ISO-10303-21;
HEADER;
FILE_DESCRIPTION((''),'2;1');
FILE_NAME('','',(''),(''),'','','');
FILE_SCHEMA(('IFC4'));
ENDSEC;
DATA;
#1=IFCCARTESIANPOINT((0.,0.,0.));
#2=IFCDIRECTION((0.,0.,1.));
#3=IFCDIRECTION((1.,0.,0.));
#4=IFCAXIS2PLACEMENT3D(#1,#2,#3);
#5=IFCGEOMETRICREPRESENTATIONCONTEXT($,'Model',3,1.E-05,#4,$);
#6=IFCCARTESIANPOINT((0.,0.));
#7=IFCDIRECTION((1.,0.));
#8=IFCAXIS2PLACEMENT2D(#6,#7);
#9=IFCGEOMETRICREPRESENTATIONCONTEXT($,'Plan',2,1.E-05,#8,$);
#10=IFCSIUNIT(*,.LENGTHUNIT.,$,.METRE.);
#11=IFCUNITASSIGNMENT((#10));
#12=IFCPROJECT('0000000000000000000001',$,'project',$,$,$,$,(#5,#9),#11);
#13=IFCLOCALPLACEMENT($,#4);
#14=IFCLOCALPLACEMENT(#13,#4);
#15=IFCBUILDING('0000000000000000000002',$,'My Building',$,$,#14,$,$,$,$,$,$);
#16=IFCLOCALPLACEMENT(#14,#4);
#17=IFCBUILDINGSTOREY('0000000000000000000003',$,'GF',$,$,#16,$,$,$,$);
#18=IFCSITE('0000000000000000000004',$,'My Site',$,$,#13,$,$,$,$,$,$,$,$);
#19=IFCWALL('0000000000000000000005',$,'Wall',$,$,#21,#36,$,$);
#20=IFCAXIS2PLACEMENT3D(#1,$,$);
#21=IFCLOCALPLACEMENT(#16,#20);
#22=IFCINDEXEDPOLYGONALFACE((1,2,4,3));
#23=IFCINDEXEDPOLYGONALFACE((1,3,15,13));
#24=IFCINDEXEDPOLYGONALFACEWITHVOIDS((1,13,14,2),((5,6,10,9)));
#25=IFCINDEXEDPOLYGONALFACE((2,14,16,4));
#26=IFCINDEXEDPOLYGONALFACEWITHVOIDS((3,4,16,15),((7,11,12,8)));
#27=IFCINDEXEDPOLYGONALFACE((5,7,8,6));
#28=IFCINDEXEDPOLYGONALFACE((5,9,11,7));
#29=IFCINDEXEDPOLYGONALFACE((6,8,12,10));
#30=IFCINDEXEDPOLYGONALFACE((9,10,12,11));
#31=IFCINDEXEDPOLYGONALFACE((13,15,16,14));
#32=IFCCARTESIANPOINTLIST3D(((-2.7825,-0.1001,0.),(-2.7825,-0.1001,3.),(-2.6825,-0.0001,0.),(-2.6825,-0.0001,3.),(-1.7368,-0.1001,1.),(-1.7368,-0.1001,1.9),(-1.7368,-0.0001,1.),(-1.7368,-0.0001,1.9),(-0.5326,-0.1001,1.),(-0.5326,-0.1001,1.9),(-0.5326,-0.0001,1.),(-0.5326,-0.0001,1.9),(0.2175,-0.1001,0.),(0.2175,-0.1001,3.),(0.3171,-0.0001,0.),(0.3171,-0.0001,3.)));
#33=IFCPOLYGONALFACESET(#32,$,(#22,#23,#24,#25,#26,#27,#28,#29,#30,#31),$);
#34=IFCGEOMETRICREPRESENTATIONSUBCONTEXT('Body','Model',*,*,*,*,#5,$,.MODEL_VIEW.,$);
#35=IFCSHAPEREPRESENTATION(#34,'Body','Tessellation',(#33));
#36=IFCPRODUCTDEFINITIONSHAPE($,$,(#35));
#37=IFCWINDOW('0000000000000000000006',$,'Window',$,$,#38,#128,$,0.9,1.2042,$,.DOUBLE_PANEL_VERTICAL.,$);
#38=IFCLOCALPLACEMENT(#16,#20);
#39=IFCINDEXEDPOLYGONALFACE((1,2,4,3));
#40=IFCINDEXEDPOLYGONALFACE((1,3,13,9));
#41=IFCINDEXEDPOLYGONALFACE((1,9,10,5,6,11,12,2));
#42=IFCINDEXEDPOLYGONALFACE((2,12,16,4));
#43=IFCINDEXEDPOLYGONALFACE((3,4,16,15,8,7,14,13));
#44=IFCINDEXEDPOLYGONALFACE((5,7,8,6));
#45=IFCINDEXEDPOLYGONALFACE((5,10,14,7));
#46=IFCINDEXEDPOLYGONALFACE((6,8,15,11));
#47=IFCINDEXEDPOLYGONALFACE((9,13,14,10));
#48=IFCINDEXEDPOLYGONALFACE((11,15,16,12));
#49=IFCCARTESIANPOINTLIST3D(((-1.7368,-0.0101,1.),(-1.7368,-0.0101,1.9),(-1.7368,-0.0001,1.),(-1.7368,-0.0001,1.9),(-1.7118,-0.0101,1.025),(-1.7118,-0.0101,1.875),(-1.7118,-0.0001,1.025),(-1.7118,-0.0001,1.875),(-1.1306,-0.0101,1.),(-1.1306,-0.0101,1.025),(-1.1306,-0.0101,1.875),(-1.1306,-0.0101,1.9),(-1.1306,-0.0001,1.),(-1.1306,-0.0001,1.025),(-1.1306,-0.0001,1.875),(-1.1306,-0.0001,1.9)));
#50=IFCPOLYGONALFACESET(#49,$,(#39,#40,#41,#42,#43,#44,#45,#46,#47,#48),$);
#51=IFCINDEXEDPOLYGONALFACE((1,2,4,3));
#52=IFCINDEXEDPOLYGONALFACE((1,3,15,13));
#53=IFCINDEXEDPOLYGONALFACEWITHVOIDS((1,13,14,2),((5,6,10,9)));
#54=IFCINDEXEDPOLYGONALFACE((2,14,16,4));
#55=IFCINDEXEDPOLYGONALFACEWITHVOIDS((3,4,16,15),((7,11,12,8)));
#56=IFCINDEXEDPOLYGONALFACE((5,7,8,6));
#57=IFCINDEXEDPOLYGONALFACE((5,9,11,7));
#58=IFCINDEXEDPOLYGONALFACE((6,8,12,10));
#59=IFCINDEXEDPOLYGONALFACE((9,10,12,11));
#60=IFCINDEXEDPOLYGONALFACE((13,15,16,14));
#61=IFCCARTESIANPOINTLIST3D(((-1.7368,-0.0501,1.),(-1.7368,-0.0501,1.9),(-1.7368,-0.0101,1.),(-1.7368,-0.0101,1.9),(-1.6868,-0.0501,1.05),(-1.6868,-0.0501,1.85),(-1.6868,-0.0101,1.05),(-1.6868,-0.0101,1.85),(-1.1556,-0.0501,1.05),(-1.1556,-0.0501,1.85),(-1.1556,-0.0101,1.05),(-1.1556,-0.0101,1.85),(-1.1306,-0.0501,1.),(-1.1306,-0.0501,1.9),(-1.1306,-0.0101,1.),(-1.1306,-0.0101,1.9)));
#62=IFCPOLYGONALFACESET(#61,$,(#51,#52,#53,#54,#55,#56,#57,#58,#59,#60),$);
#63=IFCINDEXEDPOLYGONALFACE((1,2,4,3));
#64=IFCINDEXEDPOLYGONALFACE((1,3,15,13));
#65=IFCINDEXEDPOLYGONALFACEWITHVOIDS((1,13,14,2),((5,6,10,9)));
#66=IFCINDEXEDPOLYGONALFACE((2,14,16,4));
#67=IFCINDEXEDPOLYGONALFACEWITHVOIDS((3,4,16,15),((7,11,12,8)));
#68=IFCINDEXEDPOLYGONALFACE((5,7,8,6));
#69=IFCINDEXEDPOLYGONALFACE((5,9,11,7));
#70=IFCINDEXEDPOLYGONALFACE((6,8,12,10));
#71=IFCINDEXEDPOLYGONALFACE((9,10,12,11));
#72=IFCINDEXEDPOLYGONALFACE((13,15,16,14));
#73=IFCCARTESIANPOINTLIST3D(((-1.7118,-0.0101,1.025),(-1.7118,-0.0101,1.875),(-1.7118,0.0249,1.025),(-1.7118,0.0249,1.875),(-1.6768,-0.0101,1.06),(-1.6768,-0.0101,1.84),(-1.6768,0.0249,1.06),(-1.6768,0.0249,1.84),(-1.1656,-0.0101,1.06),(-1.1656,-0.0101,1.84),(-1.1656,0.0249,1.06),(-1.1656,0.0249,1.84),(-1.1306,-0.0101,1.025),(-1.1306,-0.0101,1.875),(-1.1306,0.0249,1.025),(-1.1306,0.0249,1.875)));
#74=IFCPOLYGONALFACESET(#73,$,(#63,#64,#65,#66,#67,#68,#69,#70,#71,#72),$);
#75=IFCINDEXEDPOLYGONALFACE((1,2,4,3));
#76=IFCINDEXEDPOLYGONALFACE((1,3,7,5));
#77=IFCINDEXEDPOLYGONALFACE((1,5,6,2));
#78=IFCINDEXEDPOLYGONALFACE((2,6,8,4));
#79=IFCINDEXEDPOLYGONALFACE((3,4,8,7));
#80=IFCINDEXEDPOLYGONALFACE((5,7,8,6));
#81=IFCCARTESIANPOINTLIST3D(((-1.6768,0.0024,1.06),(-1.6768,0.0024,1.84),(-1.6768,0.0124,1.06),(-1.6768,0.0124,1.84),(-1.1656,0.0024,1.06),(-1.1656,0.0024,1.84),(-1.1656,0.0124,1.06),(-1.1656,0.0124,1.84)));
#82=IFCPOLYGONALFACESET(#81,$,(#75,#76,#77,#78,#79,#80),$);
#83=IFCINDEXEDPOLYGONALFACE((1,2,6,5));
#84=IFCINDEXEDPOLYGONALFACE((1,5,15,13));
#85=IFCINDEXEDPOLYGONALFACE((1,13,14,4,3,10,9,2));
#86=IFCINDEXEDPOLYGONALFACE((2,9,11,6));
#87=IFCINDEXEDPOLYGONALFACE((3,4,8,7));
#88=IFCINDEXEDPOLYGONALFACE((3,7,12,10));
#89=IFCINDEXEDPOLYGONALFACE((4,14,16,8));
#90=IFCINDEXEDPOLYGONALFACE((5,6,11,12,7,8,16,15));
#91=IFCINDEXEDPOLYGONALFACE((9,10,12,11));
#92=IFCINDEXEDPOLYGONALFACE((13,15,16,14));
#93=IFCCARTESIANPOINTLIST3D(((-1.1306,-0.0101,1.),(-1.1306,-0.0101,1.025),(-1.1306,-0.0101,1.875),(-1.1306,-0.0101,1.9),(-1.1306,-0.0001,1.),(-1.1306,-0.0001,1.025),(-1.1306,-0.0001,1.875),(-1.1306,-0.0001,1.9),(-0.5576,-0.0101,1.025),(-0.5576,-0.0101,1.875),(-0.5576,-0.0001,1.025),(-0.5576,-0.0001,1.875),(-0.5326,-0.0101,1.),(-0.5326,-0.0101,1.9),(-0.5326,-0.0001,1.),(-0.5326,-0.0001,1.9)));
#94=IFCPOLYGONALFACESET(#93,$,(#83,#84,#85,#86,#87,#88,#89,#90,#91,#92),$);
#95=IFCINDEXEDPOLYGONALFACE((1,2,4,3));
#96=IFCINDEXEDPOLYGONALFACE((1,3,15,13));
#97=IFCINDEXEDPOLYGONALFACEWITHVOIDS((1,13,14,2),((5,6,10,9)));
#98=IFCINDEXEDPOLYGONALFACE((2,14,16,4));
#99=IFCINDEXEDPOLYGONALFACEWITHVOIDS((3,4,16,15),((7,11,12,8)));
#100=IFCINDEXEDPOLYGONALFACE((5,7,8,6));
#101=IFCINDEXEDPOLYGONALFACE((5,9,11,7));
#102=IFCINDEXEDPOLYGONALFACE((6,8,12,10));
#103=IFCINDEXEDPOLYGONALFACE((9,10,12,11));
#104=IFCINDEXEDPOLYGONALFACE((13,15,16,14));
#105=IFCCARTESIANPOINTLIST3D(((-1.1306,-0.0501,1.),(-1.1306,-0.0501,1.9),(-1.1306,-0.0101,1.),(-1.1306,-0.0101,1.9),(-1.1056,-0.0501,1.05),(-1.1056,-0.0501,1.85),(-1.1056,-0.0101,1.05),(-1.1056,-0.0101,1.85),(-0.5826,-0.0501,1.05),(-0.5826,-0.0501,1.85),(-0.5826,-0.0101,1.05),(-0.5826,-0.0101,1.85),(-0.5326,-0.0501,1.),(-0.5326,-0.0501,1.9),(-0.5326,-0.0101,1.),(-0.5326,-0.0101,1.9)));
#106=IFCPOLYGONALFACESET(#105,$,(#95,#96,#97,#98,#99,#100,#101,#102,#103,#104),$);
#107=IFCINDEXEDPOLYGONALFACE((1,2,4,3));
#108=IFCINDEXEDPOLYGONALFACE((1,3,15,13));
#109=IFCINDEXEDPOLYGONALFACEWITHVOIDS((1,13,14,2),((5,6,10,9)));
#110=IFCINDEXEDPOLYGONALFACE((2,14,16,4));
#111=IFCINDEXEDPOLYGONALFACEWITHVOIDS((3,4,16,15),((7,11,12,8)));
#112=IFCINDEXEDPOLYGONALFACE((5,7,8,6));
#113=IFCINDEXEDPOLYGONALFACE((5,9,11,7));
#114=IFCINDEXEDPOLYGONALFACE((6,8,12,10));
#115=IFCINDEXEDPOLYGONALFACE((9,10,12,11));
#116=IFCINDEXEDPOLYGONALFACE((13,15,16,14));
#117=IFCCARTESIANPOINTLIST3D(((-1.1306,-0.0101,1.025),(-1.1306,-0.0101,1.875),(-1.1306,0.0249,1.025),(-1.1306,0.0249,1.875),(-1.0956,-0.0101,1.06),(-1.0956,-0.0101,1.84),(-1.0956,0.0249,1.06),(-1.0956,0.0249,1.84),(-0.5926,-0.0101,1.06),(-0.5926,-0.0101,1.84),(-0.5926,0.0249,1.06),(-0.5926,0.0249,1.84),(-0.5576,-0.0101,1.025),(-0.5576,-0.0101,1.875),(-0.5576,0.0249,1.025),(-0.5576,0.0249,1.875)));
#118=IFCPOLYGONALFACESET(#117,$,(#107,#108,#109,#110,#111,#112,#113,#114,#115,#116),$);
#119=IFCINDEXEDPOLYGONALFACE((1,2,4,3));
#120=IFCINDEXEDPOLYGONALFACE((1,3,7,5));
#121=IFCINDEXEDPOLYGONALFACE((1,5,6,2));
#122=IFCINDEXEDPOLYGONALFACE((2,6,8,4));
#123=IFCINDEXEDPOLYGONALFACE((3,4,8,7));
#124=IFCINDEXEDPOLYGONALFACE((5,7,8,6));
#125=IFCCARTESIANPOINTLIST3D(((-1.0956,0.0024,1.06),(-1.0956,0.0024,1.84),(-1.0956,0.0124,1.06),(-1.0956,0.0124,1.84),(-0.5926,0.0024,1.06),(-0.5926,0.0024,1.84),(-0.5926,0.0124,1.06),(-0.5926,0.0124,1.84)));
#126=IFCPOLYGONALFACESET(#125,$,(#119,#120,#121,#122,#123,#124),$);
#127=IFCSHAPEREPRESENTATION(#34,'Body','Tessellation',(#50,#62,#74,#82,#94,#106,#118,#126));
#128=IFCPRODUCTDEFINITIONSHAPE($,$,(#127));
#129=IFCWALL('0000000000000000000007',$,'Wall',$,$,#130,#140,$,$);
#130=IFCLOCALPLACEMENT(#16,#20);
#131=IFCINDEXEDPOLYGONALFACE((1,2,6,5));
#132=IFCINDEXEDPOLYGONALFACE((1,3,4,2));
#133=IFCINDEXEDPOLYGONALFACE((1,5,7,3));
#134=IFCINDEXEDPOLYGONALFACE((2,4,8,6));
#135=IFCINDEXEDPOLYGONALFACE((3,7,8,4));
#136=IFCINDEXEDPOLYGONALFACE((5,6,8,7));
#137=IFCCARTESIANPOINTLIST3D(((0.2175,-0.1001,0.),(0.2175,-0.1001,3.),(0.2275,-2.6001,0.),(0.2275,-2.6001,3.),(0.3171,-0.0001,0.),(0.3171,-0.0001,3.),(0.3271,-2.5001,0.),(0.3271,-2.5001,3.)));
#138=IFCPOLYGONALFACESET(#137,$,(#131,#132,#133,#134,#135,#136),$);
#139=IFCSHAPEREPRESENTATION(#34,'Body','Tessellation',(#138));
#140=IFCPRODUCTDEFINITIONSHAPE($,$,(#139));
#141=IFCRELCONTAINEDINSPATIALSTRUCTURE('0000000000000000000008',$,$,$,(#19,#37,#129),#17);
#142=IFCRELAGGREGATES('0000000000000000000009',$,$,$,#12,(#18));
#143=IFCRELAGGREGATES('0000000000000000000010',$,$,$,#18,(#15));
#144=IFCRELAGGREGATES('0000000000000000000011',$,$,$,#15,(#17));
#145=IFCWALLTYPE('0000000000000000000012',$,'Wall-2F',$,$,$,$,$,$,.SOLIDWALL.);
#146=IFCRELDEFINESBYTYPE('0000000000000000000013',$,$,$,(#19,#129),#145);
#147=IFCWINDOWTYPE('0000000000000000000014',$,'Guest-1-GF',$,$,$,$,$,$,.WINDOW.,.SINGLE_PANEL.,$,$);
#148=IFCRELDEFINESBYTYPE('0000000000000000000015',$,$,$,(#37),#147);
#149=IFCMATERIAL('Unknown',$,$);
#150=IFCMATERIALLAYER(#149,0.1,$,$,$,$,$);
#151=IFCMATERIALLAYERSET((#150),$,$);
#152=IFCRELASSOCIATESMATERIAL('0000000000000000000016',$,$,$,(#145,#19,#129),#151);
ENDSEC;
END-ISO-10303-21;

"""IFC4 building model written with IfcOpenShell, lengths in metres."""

from ifc_helpers import new_model, entity, si_unit, frame, origin_with_axes, origin_2d_with_axis, place, context, subcontext, project, spatial, line, indexed_curve, outline, extrude, shape, source, transform, mapped, material, layer, layer_set, layer_usage, type_object, type_shapes, element, fill, save


model = new_model("IFC4")

# Units and contexts
model_context = context("Model", 3, precision=1e-05, world=origin_with_axes())
plan_context = context("Plan", 2, precision=1e-05, world=origin_2d_with_axis())
body_context_1 = subcontext(model_context, "Body", "Model", "MODEL_VIEW")
body_context_2 = subcontext(plan_context, "Body", "Plan", "PLAN_VIEW")
ifc_project = project(units=[si_unit("LENGTHUNIT", "METRE")], contexts=[model_context, plan_context])

# Site, building, storey
site_placement = place(None, origin_with_axes())
site = spatial("IfcSite", under=ifc_project, at=site_placement, Name="My Site")
building_placement = place(site_placement, origin_with_axes())
building = spatial("IfcBuilding", under=site, at=building_placement, Name="My Building")
storey_placement = place(building_placement, origin_with_axes())
storey = spatial("IfcBuildingStorey", under=building, at=storey_placement, Name="GF")

# Shared definitions
ifc_material = material(Name="Unknown")

# Shared definitions
ifc_layer_1 = layer(ifc_material, 0.1)
ifc_layer_set_1 = layer_set([ifc_layer_1])
wall_type = type_object("IfcWallType", Name="Wall-2F", PredefinedType="SOLIDWALL", material=ifc_layer_set_1)

# Wall, opening, window
ifc_layer_usage_1 = layer_usage(ifc_layer_set_1, "AXIS2", "POSITIVE", 0.0)
wall_1_placement = place(storey_placement, frame((-2.7825, -0.1001, 0.0), z_axis=(0.0, 0.0, 1.0), x_axis=(1.0, 0.0, 0.0)))
wall_1 = element("IfcWall", 1, at=wall_1_placement, inside=storey, type_object=wall_type, material=ifc_layer_usage_1, Name="Wall", context=body_context_1, shape_type="SweptSolid", body=[
    extrude(outline(indexed_curve([(0.0, 0.0), (0.1, 0.1), (3.0996, 0.1), (3.0, 0.0)], segments=[line(1, 2, 3, 4, 1)])), origin_with_axes(), (0.0, 0.0, 1.0), 3.0),
])
shared_shape_1 = source(origin_with_axes(), body_context_1, "Body", "SweptSolid", [
    extrude(outline(indexed_curve([(0.0, 0.0), (1.2042, 0.0), (1.2042, 0.9), (0.0, 0.9)], segments=[line(1, 2, 3, 4, 1)])), frame((0.0, -0.6, 0.0), z_axis=(0.0, -1.0, 0.0), x_axis=(1.0, 0.0, 0.0)), (0.0, 0.0, -1.0), 1.2),
])
opening_1_placement = place(wall_1_placement, frame((1.0457, 0.0, 1.0), z_axis=(0.0, 0.0, 1.0), x_axis=(1.0, 0.0, 0.0)))
opening_1 = element("IfcOpeningElement", 2, at=opening_1_placement, cuts=wall_1, PredefinedType="OPENING", context=body_context_1, shape_type="MappedRepresentation", body=[
    mapped(shared_shape_1, transform((0.0, 0.0, 0.0), x_axis=(1.0, 0.0, 0.0), y_axis=(0.0, 1.0, 0.0), z_axis=(0.0, 0.0, 1.0), scale=1.0)),
])
window_type_1 = type_object("IfcWindowType", Name="Guest-1-GF", PartitioningType="SINGLE_PANEL", PredefinedType="WINDOW")
shared_shape_2 = source(origin_with_axes(), body_context_1, "Body", "SweptSolid", [
    extrude(outline(indexed_curve([(0.6062, 0.0), (0.0, 0.0), (0.0, 0.9), (0.6062, 0.9), (0.6062, 0.875), (0.025, 0.875), (0.025, 0.025), (0.6062, 0.025)], segments=[line(1, 2, 3, 4, 5, 6, 7, 8, 1)])), frame((0.0, 0.09, 0.0), z_axis=(0.0, -1.0, 0.0), x_axis=(1.0, 0.0, 0.0)), (0.0, 0.0, -1.0), 0.01),
    extrude(outline(indexed_curve([(0.0, 0.0), (0.6062, 0.0), (0.6062, 0.9), (0.0, 0.9)], segments=[line(1, 2, 3, 4, 1)]), holes=[indexed_curve([(0.05, 0.05), (0.5812, 0.05), (0.5812, 0.85), (0.05, 0.85)], segments=[line(1, 2, 3, 4, 1)])]), frame((0.0, 0.05, 0.0), z_axis=(0.0, -1.0, 0.0), x_axis=(1.0, 0.0, 0.0)), (0.0, 0.0, -1.0), 0.04),
    extrude(outline(indexed_curve([(0.0, 0.0), (0.5812, 0.0), (0.5812, 0.85), (0.0, 0.85)], segments=[line(1, 2, 3, 4, 1)]), holes=[indexed_curve([(0.035, 0.035), (0.5462, 0.035), (0.5462, 0.815), (0.035, 0.815)], segments=[line(1, 2, 3, 4, 1)])]), frame((0.025, 0.09, 0.025), z_axis=(0.0, -1.0, 0.0), x_axis=(1.0, 0.0, 0.0)), (0.0, 0.0, -1.0), 0.035),
    extrude(outline(indexed_curve([(0.035, 0.035), (0.5462, 0.035), (0.5462, 0.815), (0.035, 0.815)], segments=[line(1, 2, 3, 4, 1)])), frame((0.025, 0.1025, 0.025), z_axis=(0.0, -1.0, 0.0), x_axis=(1.0, 0.0, 0.0)), (0.0, 0.0, -1.0), 0.01),
    extrude(outline(indexed_curve([(0.0, 0.9), (0.598, 0.9), (0.598, 0.0), (0.0, 0.0), (0.0, 0.025), (0.573, 0.025), (0.573, 0.875), (0.0, 0.875)], segments=[line(1, 2, 3, 4, 5, 6, 7, 8, 1)])), frame((0.6062, 0.09, 0.0), z_axis=(0.0, -1.0, 0.0), x_axis=(1.0, 0.0, 0.0)), (0.0, 0.0, -1.0), 0.01),
    extrude(outline(indexed_curve([(0.0, 0.0), (0.598, 0.0), (0.598, 0.9), (0.0, 0.9)], segments=[line(1, 2, 3, 4, 1)]), holes=[indexed_curve([(0.025, 0.05), (0.548, 0.05), (0.548, 0.85), (0.025, 0.85)], segments=[line(1, 2, 3, 4, 1)])]), frame((0.6062, 0.05, 0.0), z_axis=(0.0, -1.0, 0.0), x_axis=(1.0, 0.0, 0.0)), (0.0, 0.0, -1.0), 0.04),
    extrude(outline(indexed_curve([(0.0, 0.0), (0.573, 0.0), (0.573, 0.85), (0.0, 0.85)], segments=[line(1, 2, 3, 4, 1)]), holes=[indexed_curve([(0.035, 0.035), (0.538, 0.035), (0.538, 0.815), (0.035, 0.815)], segments=[line(1, 2, 3, 4, 1)])]), frame((0.6062, 0.09, 0.025), z_axis=(0.0, -1.0, 0.0), x_axis=(1.0, 0.0, 0.0)), (0.0, 0.0, -1.0), 0.035),
    extrude(outline(indexed_curve([(0.035, 0.035), (0.538, 0.035), (0.538, 0.815), (0.035, 0.815)], segments=[line(1, 2, 3, 4, 1)])), frame((0.6062, 0.1025, 0.025), z_axis=(0.0, -1.0, 0.0), x_axis=(1.0, 0.0, 0.0)), (0.0, 0.0, -1.0), 0.01),
])
shared_shape_3 = source(origin_with_axes(), body_context_2, "Body", "Curve2D", [
    entity("IfcIndexedPolyCurve", entity("IfcCartesianPointList2D", [[0.05, 0.05], [0.5812, 0.05]])),
    entity("IfcIndexedPolyCurve", entity("IfcCartesianPointList2D", [[0.0, 0.1], [0.025, 0.1], [0.025, 0.09], [0.05, 0.09], [0.05, 0.05], [0.0, 0.05]]), [entity("IfcLineIndex", [1, 2, 3, 4, 5, 6, 1])]),
    entity("IfcIndexedPolyCurve", entity("IfcCartesianPointList2D", [[0.6062, 0.1], [0.6062, 0.1], [0.6062, 0.09], [0.5812, 0.09], [0.5812, 0.05], [0.6062, 0.05]])),
    entity("IfcIndexedPolyCurve", entity("IfcCartesianPointList2D", [[0.025, 0.09], [0.06, 0.09], [0.06, 0.125], [0.025, 0.125]]), [entity("IfcLineIndex", [1, 2, 3, 4, 1])]),
    entity("IfcIndexedPolyCurve", entity("IfcCartesianPointList2D", [[0.6062, 0.09], [0.5712, 0.09], [0.5712, 0.125], [0.6062, 0.125]]), [entity("IfcLineIndex", [1, 2, 3, 4, 1])]),
    entity("IfcIndexedPolyCurve", entity("IfcCartesianPointList2D", [[0.06, 0.09], [0.5712, 0.09]])),
    entity("IfcIndexedPolyCurve", entity("IfcCartesianPointList2D", [[0.06, 0.125], [0.5712, 0.125]])),
    entity("IfcIndexedPolyCurve", entity("IfcCartesianPointList2D", [[0.06, 0.1075], [0.5712, 0.1075]])),
    entity("IfcIndexedPolyCurve", entity("IfcCartesianPointList2D", [[0.6312, 0.05], [1.1542, 0.05]])),
    entity("IfcIndexedPolyCurve", entity("IfcCartesianPointList2D", [[0.6062, 0.1], [0.6062, 0.1], [0.6062, 0.09], [0.6312, 0.09], [0.6312, 0.05], [0.6062, 0.05]])),
    entity("IfcIndexedPolyCurve", entity("IfcCartesianPointList2D", [[1.2042, 0.1], [1.1792, 0.1], [1.1792, 0.09], [1.1542, 0.09], [1.1542, 0.05], [1.2042, 0.05]]), [entity("IfcLineIndex", [1, 2, 3, 4, 5, 6, 1])]),
    entity("IfcIndexedPolyCurve", entity("IfcCartesianPointList2D", [[0.6062, 0.09], [0.6412, 0.09], [0.6412, 0.125], [0.6062, 0.125]]), [entity("IfcLineIndex", [1, 2, 3, 4, 1])]),
    entity("IfcIndexedPolyCurve", entity("IfcCartesianPointList2D", [[1.1792, 0.09], [1.1442, 0.09], [1.1442, 0.125], [1.1792, 0.125]]), [entity("IfcLineIndex", [1, 2, 3, 4, 1])]),
    entity("IfcIndexedPolyCurve", entity("IfcCartesianPointList2D", [[0.6412, 0.09], [1.1442, 0.09]])),
    entity("IfcIndexedPolyCurve", entity("IfcCartesianPointList2D", [[0.6412, 0.125], [1.1442, 0.125]])),
    entity("IfcIndexedPolyCurve", entity("IfcCartesianPointList2D", [[0.6412, 0.1075], [1.1442, 0.1075]])),
])
type_shapes(window_type_1, [shared_shape_2, shared_shape_3])
window_1_placement = place(opening_1_placement, frame((0.0, 0.0, 0.0), z_axis=(0.0, 0.0, 1.0), x_axis=(1.0, 0.0, 0.0)))
window_1 = element("IfcWindow", 3, at=window_1_placement, inside=storey, type_object=window_type_1, Name="Window", OverallHeight=0.9, OverallWidth=1.2042, PartitioningType="DOUBLE_PANEL_VERTICAL", shapes=[
    shape(body_context_1, "Body", "MappedRepresentation", [mapped(shared_shape_2, transform((0.0, 0.0, 0.0), x_axis=(1.0, 0.0, 0.0), y_axis=(0.0, 1.0, 0.0), z_axis=(0.0, 0.0, 1.0), scale=1.0))]),
    shape(body_context_2, "Body", "MappedRepresentation", [mapped(shared_shape_3, transform((0.0, 0.0, 0.0), x_axis=(1.0, 0.0, 0.0), y_axis=(0.0, 1.0, 0.0), z_axis=(0.0, 0.0, 1.0), scale=1.0))]),
])
fill(opening_1, window_1)

# Wall
ifc_layer_usage_2 = layer_usage(ifc_layer_set_1, "AXIS2", "POSITIVE", 0.0)
wall_2_placement = place(storey_placement, frame((0.2175, -0.1001, 0.0), z_axis=(0.0, 0.0, 1.0), x_axis=(0.004, -0.999992, 0.0)))
element("IfcWall", 4, at=wall_2_placement, inside=storey, type_object=wall_type, material=ifc_layer_usage_2, Name="Wall", context=body_context_1, shape_type="SweptSolid", body=[
    extrude(outline(indexed_curve([(0.0, 0.0), (-0.0996, 0.1), (2.4004, 0.1), (2.5, 0.0)], segments=[line(1, 2, 3, 4, 1)])), origin_with_axes(), (0.0, 0.0, 1.0), 3.0),
])

save(model, "model.ifc")
